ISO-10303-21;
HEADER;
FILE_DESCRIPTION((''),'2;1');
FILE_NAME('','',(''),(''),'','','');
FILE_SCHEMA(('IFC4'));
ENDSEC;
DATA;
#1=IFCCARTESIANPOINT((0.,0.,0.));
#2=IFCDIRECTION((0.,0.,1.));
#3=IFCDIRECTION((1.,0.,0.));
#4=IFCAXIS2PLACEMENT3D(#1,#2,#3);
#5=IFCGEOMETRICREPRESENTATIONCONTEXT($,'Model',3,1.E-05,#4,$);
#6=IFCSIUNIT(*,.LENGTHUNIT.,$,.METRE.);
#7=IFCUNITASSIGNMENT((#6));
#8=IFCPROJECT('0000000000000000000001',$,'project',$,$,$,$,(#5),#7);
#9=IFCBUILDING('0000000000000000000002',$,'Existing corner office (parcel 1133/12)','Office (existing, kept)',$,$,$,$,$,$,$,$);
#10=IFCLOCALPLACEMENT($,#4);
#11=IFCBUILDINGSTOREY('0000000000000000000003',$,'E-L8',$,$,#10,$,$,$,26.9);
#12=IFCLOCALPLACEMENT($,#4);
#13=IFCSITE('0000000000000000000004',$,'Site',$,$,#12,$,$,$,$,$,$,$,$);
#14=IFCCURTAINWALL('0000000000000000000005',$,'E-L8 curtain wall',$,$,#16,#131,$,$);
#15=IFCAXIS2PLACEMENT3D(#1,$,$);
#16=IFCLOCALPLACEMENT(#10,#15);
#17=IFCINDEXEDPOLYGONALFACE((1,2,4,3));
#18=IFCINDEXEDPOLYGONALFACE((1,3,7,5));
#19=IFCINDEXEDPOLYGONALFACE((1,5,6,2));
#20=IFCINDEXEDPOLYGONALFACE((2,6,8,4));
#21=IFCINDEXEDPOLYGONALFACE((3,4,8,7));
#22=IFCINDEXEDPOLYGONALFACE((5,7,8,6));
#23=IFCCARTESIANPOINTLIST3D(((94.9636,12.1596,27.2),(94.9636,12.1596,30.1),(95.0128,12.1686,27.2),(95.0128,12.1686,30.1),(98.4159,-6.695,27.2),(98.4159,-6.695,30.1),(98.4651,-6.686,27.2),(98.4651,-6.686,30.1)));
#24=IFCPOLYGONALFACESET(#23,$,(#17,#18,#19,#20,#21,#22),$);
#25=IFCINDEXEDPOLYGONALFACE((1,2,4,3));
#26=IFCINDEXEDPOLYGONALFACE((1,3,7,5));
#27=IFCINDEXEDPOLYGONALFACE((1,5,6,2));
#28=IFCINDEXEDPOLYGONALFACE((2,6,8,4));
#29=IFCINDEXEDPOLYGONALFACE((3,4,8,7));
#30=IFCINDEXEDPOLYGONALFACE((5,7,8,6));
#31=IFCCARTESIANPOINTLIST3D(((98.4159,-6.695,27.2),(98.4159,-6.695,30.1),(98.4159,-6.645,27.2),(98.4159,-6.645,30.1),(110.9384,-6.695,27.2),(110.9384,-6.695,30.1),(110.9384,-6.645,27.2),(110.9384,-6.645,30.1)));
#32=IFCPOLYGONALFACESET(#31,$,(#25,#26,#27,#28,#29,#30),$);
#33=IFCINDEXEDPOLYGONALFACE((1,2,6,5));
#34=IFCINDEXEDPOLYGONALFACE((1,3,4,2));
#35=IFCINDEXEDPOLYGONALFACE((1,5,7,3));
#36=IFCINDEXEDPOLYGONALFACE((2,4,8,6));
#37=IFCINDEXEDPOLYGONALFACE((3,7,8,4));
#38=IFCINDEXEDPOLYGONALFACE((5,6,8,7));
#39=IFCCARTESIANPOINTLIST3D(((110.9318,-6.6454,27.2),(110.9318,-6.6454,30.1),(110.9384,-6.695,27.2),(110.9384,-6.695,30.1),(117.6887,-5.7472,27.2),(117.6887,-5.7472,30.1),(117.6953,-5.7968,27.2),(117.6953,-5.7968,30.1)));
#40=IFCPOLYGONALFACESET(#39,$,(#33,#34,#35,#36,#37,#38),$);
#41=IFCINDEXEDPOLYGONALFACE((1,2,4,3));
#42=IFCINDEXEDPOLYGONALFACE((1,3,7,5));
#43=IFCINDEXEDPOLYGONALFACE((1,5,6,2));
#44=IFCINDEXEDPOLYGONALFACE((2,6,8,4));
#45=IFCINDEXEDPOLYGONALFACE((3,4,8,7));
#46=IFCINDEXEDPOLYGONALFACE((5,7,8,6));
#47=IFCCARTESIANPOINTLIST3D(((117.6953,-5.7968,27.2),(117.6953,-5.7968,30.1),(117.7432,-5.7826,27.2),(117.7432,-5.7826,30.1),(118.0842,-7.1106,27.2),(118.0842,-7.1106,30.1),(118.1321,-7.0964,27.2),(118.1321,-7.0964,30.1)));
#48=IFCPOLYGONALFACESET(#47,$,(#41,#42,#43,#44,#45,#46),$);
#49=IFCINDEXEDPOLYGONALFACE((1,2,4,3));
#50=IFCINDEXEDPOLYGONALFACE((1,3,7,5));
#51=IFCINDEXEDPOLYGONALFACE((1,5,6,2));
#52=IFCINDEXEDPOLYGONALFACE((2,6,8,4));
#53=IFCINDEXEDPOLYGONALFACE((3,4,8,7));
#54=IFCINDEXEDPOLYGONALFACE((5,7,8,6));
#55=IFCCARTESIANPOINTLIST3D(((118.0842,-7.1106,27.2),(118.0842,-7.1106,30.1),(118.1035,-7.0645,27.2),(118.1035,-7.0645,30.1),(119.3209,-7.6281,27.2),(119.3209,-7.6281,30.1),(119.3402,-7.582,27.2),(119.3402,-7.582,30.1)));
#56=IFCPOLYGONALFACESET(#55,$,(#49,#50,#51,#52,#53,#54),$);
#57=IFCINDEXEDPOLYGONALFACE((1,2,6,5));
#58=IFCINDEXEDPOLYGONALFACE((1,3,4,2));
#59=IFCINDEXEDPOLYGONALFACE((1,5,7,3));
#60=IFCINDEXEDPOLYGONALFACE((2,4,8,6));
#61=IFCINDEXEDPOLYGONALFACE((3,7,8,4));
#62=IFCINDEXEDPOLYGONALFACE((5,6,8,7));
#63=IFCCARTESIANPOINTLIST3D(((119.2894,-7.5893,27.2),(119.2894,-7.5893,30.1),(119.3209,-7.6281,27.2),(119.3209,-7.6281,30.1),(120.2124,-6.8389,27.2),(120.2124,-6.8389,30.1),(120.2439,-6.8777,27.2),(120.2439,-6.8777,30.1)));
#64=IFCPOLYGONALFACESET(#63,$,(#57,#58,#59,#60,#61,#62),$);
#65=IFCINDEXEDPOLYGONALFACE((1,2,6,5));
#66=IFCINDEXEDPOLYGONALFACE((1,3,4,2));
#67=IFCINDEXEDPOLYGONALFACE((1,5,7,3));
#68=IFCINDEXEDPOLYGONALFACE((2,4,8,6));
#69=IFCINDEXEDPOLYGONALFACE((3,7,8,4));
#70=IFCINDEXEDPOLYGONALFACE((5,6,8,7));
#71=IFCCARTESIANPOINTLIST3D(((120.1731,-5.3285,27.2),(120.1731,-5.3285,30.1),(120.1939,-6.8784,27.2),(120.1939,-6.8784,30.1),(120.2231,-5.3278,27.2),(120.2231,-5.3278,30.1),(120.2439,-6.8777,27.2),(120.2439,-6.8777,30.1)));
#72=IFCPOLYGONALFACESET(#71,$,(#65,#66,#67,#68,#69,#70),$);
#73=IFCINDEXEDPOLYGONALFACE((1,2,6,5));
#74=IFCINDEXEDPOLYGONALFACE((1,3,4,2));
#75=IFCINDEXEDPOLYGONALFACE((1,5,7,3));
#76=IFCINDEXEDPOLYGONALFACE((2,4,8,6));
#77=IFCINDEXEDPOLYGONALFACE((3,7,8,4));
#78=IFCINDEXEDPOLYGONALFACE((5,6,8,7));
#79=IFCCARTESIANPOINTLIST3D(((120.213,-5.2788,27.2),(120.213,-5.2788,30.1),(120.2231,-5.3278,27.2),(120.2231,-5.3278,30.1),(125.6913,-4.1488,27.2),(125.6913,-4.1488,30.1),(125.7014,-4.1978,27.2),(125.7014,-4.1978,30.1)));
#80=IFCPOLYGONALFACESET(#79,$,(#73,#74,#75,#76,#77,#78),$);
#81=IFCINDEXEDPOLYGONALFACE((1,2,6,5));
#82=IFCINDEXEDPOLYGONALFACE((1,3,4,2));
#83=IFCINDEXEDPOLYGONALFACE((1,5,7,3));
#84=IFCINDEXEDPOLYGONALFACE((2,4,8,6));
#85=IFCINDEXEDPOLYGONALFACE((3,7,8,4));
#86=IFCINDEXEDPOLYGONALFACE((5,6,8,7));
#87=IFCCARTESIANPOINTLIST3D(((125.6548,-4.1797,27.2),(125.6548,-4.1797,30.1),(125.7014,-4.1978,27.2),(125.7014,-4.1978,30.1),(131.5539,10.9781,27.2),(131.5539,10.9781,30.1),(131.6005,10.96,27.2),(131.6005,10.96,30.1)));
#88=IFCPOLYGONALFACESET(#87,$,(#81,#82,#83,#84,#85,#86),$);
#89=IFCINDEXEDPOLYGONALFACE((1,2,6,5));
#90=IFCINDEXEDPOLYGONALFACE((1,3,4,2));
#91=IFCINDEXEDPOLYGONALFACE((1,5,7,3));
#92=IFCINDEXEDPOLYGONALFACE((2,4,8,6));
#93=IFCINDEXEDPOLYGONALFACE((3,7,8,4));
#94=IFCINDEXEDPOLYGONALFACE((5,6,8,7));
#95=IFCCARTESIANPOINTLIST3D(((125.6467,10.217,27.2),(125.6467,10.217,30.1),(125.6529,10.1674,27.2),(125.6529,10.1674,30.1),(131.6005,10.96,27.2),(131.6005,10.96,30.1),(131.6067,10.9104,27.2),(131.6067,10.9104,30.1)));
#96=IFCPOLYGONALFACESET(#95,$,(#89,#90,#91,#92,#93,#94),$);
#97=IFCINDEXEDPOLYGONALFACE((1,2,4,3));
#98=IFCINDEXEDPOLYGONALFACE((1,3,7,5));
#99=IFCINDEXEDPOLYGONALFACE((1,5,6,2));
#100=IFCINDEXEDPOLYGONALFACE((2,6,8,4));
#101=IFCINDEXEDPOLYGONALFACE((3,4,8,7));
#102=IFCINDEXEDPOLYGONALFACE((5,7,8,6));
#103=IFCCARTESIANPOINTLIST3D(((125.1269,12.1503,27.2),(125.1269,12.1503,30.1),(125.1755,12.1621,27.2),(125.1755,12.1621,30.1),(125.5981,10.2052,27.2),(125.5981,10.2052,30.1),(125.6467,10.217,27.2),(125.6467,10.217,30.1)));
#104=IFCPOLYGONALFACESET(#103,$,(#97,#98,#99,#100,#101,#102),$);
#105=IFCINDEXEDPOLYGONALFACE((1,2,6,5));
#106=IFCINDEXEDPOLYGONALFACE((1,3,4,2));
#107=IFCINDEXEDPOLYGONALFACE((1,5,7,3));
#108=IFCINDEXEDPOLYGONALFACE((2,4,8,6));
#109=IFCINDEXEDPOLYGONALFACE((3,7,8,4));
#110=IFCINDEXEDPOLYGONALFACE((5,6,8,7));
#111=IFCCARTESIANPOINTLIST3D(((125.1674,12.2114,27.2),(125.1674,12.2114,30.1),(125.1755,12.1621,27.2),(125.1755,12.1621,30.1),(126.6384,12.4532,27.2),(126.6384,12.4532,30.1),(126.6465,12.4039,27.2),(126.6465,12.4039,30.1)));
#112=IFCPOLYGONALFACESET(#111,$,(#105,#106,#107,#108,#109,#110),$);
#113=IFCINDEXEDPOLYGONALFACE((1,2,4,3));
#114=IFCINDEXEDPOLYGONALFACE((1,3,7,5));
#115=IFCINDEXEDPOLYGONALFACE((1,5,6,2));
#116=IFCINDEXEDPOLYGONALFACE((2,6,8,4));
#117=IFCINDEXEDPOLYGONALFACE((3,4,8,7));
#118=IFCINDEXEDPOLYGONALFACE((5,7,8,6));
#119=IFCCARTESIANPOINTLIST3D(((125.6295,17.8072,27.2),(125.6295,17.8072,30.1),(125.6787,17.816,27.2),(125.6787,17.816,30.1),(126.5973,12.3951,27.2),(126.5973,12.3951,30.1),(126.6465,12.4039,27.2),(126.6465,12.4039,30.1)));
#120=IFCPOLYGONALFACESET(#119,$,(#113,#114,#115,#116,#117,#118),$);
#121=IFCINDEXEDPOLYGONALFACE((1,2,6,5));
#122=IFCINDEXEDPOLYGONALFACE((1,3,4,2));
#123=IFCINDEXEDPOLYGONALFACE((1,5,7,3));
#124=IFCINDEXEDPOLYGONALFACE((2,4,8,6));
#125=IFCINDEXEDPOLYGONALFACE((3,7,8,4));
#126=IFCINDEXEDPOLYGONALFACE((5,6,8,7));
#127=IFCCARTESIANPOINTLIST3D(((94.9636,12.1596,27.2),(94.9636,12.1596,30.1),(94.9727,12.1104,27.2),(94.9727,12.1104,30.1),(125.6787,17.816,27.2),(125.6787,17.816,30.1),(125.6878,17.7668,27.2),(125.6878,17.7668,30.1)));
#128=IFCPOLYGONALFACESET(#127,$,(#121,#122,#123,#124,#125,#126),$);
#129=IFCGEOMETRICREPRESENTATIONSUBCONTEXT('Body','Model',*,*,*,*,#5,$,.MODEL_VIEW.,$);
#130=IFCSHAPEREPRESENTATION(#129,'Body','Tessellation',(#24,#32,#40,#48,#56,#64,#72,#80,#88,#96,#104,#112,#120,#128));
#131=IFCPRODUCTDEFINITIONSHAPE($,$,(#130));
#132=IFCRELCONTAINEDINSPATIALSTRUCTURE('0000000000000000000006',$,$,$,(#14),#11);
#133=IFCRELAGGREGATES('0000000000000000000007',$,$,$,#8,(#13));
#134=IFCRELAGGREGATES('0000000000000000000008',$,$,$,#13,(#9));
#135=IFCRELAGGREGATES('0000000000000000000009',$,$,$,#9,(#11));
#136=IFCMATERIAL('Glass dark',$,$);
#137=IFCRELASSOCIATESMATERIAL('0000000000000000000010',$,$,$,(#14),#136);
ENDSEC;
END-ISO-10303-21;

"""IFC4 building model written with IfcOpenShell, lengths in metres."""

from ifc_helpers import new_model, si_unit, frame, origin_with_axes, place, context, subcontext, project, spatial, polyline, outline, extrude, material, element, save


model = new_model("IFC4")

# Units and contexts
model_context = context("Model", 3, precision=1e-05, world=origin_with_axes())
body_context = subcontext(model_context, "Body", "Model", "MODEL_VIEW")
ifc_project = project(units=[si_unit("LENGTHUNIT", "METRE")], contexts=[model_context])

# Site, building, storey
site_placement = place(None, origin_with_axes())
site = spatial("IfcSite", under=ifc_project, at=site_placement, Name="Site")
building = spatial("IfcBuilding", under=site, Name="Existing corner office (parcel 1133/12)", Description="Office (existing, kept)")
storey_placement = place(None, origin_with_axes())
storey = spatial("IfcBuildingStorey", under=building, at=storey_placement, Name="E-L8", Elevation=26.9)

# Curtain wall
ifc_material_1 = material(Name="Glass dark")
curtain_wall_placement = place(storey_placement, origin_with_axes())
element("IfcCurtainWall", 1, at=curtain_wall_placement, inside=storey, material=ifc_material_1, Name="E-L8 curtain wall", context=body_context, shape_type="SweptSolid", body=[
    extrude(outline(polyline([(94.9636, 12.1596), (98.4159, -6.695), (98.4651, -6.686), (95.0128, 12.1686), (94.9636, 12.1596)])), frame((0.0, 0.0, 27.2), z_axis=(0.0, 0.0, 1.0), x_axis=(1.0, 0.0, 0.0)), (0.0, 0.0, 1.0), 2.9),
    extrude(outline(polyline([(98.4159, -6.695), (110.9384, -6.695), (110.9384, -6.645), (98.4159, -6.645), (98.4159, -6.695)])), frame((0.0, 0.0, 27.2), z_axis=(0.0, 0.0, 1.0), x_axis=(1.0, 0.0, 0.0)), (0.0, 0.0, 1.0), 2.9),
    extrude(outline(polyline([(110.9384, -6.695), (117.6953, -5.7968), (117.6887, -5.7472), (110.9318, -6.6454), (110.9384, -6.695)])), frame((0.0, 0.0, 27.2), z_axis=(0.0, 0.0, 1.0), x_axis=(1.0, 0.0, 0.0)), (0.0, 0.0, 1.0), 2.9),
    extrude(outline(polyline([(117.6953, -5.7968), (118.0842, -7.1106), (118.1321, -7.0964), (117.7432, -5.7826), (117.6953, -5.7968)])), frame((0.0, 0.0, 27.2), z_axis=(0.0, 0.0, 1.0), x_axis=(1.0, 0.0, 0.0)), (0.0, 0.0, 1.0), 2.9),
    extrude(outline(polyline([(118.0842, -7.1106), (119.3209, -7.6281), (119.3402, -7.582), (118.1035, -7.0645), (118.0842, -7.1106)])), frame((0.0, 0.0, 27.2), z_axis=(0.0, 0.0, 1.0), x_axis=(1.0, 0.0, 0.0)), (0.0, 0.0, 1.0), 2.9),
    extrude(outline(polyline([(119.3209, -7.6281), (120.2439, -6.8777), (120.2124, -6.8389), (119.2894, -7.5893), (119.3209, -7.6281)])), frame((0.0, 0.0, 27.2), z_axis=(0.0, 0.0, 1.0), x_axis=(1.0, 0.0, 0.0)), (0.0, 0.0, 1.0), 2.9),
    extrude(outline(polyline([(120.2439, -6.8777), (120.2231, -5.3278), (120.1731, -5.3285), (120.1939, -6.8784), (120.2439, -6.8777)])), frame((0.0, 0.0, 27.2), z_axis=(0.0, 0.0, 1.0), x_axis=(1.0, 0.0, 0.0)), (0.0, 0.0, 1.0), 2.9),
    extrude(outline(polyline([(120.2231, -5.3278), (125.7014, -4.1978), (125.6913, -4.1488), (120.213, -5.2788), (120.2231, -5.3278)])), frame((0.0, 0.0, 27.2), z_axis=(0.0, 0.0, 1.0), x_axis=(1.0, 0.0, 0.0)), (0.0, 0.0, 1.0), 2.9),
    extrude(outline(polyline([(125.7014, -4.1978), (131.6005, 10.96), (131.5539, 10.9781), (125.6548, -4.1797), (125.7014, -4.1978)])), frame((0.0, 0.0, 27.2), z_axis=(0.0, 0.0, 1.0), x_axis=(1.0, 0.0, 0.0)), (0.0, 0.0, 1.0), 2.9),
    extrude(outline(polyline([(131.6005, 10.96), (125.6467, 10.217), (125.6529, 10.1674), (131.6067, 10.9104), (131.6005, 10.96)])), frame((0.0, 0.0, 27.2), z_axis=(0.0, 0.0, 1.0), x_axis=(1.0, 0.0, 0.0)), (0.0, 0.0, 1.0), 2.9),
    extrude(outline(polyline([(125.6467, 10.217), (125.1755, 12.1621), (125.1269, 12.1503), (125.5981, 10.2052), (125.6467, 10.217)])), frame((0.0, 0.0, 27.2), z_axis=(0.0, 0.0, 1.0), x_axis=(1.0, 0.0, 0.0)), (0.0, 0.0, 1.0), 2.9),
    extrude(outline(polyline([(125.1755, 12.1621), (126.6465, 12.4039), (126.6384, 12.4532), (125.1674, 12.2114), (125.1755, 12.1621)])), frame((0.0, 0.0, 27.2), z_axis=(0.0, 0.0, 1.0), x_axis=(1.0, 0.0, 0.0)), (0.0, 0.0, 1.0), 2.9),
    extrude(outline(polyline([(126.6465, 12.4039), (125.6787, 17.816), (125.6295, 17.8072), (126.5973, 12.3951), (126.6465, 12.4039)])), frame((0.0, 0.0, 27.2), z_axis=(0.0, 0.0, 1.0), x_axis=(1.0, 0.0, 0.0)), (0.0, 0.0, 1.0), 2.9),
    extrude(outline(polyline([(125.6787, 17.816), (94.9636, 12.1596), (94.9727, 12.1104), (125.6878, 17.7668), (125.6787, 17.816)])), frame((0.0, 0.0, 27.2), z_axis=(0.0, 0.0, 1.0), x_axis=(1.0, 0.0, 0.0)), (0.0, 0.0, 1.0), 2.9),
])

save(model, "model.ifc")
